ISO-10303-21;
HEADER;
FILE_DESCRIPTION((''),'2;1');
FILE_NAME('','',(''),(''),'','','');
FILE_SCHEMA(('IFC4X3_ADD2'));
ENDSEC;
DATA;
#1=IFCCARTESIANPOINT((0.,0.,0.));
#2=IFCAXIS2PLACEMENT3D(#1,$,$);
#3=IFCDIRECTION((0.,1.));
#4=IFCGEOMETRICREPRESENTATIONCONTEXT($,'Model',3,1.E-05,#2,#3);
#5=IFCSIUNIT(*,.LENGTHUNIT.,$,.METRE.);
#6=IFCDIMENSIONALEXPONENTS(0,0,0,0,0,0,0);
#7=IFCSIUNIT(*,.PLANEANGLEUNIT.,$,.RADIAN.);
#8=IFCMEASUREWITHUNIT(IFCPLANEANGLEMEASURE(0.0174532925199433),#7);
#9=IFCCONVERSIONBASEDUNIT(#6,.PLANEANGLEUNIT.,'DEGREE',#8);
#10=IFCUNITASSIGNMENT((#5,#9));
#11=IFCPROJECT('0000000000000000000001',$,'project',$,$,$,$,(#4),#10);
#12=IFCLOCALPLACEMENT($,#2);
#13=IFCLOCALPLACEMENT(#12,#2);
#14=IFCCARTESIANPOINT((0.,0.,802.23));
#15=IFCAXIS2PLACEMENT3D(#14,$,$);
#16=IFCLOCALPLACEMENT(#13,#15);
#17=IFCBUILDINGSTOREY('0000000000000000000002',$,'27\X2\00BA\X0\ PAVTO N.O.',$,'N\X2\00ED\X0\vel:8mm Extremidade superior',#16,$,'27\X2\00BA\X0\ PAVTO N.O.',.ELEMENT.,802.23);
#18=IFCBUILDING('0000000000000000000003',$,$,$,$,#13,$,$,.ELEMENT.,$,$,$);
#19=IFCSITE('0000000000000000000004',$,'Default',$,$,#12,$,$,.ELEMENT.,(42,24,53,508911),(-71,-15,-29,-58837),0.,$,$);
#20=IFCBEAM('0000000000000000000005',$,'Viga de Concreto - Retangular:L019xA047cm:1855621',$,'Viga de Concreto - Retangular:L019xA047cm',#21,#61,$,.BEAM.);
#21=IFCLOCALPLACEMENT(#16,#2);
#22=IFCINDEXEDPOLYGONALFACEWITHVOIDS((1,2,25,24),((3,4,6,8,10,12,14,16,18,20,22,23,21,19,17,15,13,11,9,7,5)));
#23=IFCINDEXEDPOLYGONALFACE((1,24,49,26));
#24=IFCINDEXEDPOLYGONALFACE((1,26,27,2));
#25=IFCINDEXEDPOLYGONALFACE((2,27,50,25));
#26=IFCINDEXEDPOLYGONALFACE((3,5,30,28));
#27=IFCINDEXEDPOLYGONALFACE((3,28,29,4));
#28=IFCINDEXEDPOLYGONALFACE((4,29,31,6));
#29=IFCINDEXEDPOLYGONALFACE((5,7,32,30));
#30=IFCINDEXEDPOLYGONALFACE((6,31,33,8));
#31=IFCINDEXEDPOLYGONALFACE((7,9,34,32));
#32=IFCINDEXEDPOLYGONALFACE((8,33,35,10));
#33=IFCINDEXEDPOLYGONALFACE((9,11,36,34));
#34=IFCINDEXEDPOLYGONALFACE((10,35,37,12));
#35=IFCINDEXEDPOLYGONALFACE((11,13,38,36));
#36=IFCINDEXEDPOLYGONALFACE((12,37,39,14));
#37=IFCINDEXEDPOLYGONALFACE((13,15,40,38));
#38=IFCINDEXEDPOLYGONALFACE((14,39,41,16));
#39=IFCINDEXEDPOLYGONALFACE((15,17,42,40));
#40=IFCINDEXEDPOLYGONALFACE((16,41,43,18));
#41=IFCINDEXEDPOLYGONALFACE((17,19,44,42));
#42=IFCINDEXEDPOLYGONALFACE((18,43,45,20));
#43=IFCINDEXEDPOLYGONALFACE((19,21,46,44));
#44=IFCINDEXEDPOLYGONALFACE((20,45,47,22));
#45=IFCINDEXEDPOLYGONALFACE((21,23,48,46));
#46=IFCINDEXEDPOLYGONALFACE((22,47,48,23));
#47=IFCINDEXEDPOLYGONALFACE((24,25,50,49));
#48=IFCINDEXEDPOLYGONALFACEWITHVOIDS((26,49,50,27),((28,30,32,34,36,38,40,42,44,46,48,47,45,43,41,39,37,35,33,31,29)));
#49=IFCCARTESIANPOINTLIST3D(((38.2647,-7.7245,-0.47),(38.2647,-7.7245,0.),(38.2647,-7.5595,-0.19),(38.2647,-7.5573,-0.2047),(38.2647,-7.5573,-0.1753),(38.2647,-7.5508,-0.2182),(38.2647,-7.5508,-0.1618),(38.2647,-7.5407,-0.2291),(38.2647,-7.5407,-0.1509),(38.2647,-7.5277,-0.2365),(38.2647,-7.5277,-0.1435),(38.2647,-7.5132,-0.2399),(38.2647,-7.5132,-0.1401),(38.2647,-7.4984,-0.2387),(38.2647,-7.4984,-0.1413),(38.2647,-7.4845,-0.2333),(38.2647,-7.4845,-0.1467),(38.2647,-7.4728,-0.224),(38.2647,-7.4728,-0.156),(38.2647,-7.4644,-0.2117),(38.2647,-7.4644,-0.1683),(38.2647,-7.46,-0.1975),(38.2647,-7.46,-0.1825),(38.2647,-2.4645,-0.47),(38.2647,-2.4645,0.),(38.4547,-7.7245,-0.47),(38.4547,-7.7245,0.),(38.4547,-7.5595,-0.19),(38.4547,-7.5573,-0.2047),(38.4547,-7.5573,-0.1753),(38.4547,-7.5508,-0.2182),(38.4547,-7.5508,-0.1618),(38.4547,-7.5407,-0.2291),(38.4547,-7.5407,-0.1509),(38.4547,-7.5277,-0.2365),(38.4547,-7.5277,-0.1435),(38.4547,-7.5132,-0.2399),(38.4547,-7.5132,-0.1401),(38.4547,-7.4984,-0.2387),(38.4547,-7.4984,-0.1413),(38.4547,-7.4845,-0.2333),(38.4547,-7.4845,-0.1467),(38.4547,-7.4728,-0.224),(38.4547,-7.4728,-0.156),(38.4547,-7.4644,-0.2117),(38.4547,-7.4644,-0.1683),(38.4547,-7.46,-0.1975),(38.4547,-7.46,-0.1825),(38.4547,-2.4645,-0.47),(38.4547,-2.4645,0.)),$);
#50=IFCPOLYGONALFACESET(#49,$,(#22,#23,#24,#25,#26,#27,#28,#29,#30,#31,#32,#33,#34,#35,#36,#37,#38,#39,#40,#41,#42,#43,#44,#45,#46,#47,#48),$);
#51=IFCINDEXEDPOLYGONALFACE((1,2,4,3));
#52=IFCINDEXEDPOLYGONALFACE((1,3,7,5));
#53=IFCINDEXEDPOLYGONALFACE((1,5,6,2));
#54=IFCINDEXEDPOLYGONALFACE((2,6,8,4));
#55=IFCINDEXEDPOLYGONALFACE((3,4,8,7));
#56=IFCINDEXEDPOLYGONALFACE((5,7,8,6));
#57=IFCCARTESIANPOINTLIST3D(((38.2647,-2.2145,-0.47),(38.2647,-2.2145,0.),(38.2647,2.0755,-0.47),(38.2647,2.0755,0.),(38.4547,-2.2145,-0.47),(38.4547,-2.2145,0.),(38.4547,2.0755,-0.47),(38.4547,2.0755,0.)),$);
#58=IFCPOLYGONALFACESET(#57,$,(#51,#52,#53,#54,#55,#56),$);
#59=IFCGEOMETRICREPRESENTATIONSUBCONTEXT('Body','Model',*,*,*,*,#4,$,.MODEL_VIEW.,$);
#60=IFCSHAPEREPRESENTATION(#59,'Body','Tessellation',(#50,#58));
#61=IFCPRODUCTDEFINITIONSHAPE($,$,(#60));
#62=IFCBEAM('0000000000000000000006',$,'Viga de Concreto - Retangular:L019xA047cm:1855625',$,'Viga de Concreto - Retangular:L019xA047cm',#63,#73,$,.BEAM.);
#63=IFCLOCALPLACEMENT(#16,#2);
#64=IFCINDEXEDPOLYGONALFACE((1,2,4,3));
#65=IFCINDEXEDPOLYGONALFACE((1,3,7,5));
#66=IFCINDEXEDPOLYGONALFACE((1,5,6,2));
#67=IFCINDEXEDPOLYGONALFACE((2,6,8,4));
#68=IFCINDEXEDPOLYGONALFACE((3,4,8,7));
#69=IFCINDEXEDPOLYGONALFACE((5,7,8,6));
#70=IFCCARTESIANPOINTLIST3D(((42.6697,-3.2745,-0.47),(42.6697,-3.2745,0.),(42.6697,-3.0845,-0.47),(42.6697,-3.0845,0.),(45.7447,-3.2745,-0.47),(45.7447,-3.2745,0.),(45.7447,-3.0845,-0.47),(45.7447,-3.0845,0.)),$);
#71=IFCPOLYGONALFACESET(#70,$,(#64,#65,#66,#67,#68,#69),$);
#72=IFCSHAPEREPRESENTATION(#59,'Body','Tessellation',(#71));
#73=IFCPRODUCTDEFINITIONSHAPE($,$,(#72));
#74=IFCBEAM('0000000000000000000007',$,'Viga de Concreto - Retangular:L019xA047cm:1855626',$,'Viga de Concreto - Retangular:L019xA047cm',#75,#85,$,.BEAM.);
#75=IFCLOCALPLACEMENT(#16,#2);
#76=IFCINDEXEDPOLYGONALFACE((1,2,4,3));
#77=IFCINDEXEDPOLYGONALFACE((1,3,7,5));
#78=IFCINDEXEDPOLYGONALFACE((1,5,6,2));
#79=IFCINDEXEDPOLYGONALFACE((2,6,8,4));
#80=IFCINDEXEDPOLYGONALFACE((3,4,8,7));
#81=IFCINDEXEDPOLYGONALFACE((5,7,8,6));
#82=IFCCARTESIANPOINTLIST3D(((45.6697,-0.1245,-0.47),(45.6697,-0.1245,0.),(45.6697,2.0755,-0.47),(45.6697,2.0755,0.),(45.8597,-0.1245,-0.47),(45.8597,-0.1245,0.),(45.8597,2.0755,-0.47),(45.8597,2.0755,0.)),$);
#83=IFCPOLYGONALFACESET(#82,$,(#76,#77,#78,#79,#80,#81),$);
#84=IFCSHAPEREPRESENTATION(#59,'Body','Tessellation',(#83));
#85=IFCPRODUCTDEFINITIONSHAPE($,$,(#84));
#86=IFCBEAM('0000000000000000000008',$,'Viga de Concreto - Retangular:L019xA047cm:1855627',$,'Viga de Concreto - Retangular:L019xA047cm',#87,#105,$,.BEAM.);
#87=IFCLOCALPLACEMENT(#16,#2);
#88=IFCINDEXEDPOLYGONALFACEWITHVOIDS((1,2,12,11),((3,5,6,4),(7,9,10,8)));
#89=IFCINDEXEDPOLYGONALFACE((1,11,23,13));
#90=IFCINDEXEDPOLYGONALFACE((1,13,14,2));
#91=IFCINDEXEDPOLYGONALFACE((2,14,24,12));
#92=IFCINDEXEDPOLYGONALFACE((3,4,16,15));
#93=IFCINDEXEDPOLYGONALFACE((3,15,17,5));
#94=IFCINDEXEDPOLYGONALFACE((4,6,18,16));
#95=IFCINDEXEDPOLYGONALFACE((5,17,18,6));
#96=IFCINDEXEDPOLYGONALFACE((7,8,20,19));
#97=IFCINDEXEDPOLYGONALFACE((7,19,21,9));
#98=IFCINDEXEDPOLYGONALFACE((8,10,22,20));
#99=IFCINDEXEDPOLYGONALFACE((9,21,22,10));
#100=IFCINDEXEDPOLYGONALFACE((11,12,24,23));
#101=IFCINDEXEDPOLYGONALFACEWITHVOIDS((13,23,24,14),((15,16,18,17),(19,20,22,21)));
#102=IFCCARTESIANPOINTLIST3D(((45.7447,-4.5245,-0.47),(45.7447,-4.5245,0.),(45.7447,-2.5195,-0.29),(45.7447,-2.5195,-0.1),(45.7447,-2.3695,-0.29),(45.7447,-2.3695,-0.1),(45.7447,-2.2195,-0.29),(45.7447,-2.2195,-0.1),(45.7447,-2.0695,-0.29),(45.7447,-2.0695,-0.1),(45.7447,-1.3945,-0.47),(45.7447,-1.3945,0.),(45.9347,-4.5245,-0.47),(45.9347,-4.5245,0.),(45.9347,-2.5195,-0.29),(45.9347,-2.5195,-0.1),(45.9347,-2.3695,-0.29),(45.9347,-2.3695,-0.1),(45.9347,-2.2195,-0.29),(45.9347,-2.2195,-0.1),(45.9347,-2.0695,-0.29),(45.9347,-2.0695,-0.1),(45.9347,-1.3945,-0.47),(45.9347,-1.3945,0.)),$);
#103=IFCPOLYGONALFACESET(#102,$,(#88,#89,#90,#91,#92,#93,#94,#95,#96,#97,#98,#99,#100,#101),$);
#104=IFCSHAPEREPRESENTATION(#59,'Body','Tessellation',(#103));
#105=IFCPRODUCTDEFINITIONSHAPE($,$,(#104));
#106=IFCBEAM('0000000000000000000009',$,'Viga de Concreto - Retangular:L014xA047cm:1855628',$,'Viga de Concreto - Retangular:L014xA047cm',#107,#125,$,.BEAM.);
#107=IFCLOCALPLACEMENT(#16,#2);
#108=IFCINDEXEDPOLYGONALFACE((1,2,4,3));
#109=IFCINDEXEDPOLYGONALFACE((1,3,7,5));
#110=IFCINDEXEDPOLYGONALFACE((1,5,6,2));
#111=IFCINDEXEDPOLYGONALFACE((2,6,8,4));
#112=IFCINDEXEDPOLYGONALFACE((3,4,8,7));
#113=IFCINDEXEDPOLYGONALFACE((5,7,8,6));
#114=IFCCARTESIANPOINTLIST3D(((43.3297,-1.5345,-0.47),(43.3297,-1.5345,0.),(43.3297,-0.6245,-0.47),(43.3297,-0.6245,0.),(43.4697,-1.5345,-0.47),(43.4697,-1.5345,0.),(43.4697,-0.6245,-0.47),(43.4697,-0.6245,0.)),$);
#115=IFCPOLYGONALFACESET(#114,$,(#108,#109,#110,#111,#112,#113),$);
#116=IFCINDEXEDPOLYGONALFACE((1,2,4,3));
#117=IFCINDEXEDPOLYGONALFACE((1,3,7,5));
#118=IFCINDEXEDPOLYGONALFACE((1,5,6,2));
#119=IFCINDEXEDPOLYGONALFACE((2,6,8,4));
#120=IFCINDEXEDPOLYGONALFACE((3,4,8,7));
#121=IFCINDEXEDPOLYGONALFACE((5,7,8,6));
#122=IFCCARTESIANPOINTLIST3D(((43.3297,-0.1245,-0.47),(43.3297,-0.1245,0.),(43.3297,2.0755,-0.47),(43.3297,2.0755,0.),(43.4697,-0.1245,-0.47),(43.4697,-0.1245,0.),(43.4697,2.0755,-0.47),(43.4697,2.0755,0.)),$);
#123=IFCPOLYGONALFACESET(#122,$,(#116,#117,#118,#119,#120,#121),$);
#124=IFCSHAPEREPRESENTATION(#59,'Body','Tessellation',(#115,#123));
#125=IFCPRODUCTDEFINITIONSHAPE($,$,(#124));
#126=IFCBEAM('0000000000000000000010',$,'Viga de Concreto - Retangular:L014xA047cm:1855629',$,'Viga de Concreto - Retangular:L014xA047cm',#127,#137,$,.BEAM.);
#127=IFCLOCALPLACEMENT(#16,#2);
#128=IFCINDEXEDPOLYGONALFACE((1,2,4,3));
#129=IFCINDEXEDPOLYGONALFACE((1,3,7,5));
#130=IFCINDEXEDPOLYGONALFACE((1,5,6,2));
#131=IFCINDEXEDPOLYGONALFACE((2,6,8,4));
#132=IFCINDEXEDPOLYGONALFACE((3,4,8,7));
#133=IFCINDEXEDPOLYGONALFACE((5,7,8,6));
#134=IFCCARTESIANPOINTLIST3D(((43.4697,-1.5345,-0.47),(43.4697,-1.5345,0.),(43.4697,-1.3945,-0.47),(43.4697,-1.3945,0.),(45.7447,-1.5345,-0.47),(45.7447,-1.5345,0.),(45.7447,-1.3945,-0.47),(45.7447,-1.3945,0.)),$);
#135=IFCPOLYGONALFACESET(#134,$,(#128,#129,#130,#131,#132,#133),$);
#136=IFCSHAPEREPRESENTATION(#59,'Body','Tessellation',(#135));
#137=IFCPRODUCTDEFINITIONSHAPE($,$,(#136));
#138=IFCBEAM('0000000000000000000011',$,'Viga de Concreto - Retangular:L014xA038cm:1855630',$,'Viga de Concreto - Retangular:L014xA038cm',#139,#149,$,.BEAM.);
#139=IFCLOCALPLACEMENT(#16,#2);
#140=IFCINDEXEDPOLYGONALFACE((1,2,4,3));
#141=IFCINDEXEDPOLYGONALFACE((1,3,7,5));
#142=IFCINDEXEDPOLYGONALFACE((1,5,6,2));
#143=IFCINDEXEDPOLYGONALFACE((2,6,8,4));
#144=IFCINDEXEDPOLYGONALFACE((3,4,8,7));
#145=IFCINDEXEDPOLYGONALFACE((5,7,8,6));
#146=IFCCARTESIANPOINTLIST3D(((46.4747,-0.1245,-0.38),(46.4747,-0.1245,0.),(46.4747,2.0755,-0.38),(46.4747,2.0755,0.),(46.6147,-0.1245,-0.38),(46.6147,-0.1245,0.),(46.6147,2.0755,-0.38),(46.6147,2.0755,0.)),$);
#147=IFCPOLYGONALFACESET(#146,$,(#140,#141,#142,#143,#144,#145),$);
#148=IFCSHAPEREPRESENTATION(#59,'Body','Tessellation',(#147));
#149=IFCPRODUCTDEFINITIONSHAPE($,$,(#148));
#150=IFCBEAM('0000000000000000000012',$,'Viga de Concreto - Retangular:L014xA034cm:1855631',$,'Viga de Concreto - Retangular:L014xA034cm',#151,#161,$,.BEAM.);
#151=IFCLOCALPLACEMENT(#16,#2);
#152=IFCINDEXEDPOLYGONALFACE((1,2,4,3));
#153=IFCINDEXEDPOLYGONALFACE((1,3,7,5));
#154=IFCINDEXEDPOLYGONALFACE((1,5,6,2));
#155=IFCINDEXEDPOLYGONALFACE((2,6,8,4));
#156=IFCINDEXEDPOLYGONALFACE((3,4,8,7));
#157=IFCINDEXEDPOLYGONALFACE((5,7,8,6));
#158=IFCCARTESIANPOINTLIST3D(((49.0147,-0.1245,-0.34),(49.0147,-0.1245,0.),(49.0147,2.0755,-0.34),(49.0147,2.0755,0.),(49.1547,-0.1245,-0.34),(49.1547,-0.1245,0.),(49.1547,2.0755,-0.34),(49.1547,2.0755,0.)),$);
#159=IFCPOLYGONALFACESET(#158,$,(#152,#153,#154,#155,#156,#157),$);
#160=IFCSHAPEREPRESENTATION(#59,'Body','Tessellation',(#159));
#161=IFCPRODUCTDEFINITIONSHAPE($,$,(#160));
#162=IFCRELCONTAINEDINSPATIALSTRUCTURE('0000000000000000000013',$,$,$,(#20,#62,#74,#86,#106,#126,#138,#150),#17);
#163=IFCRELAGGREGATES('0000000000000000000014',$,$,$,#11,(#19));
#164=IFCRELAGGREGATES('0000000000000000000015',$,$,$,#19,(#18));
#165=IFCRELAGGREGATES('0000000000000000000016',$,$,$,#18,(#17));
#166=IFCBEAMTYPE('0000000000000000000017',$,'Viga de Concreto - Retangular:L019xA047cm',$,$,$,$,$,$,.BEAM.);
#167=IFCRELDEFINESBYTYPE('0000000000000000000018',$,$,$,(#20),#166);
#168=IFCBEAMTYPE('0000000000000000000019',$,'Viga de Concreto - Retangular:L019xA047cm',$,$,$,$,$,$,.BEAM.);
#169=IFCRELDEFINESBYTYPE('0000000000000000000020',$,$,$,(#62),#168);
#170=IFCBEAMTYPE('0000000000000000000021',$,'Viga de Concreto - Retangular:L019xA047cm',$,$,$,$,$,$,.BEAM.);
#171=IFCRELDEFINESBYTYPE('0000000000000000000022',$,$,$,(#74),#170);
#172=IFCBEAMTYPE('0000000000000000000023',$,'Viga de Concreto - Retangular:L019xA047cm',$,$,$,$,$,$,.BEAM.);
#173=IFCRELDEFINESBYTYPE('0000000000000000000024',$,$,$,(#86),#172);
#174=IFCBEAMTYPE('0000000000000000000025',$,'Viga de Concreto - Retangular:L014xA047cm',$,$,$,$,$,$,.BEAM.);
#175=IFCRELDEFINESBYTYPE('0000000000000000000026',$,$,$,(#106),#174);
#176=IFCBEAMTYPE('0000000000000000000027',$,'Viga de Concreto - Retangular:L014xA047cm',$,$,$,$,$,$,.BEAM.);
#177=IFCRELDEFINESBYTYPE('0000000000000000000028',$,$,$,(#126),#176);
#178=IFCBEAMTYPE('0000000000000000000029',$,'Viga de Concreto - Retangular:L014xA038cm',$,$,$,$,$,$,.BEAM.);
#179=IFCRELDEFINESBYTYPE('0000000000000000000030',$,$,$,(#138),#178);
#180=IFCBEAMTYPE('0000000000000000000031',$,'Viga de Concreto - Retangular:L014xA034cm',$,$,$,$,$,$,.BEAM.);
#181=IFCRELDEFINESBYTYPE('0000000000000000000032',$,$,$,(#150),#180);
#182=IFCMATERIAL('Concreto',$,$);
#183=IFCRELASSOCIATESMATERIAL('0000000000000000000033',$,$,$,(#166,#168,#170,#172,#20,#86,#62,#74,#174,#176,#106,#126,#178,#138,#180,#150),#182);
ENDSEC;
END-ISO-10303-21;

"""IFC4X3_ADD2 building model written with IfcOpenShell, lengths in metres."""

from ifc_helpers import new_model, entity, si_unit, converted_unit, direction, frame, frame_2d, origin, origin_2d_with_axis, place, context, subcontext, project, spatial, rectangle, circle, extrude, boolean, source, transform, mapped, material, material_profile, profile_set, profile_usage, type_object, type_shapes, element, save


model = new_model("IFC4X3_ADD2")

# Units and contexts
model_context = context("Model", 3, precision=1e-05, world=origin(), true_north=direction((0.0, 1.0)))
body_context = subcontext(model_context, "Body", "Model", "MODEL_VIEW")
ifc_project = project(units=[si_unit("LENGTHUNIT", "METRE"), converted_unit("PLANEANGLEUNIT", "DEGREE", entity("IfcPlaneAngleMeasure", 0.0174532925199433), si_unit("PLANEANGLEUNIT", "RADIAN"), dimensions=[0, 0, 0, 0, 0, 0, 0])], contexts=[model_context])

# Site, building, storey
site_placement = place(None, origin())
site = spatial("IfcSite", under=ifc_project, at=site_placement, Name="Default", CompositionType="ELEMENT", RefLatitude=(42, 24, 53, 508911), RefLongitude=(-71, -15, -29, -58837), RefElevation=0.0)
building_placement = place(site_placement, origin())
building = spatial("IfcBuilding", under=site, at=building_placement, CompositionType="ELEMENT")
storey_placement = place(building_placement, frame((0.0, 0.0, 802.23)))
storey = spatial("IfcBuildingStorey", under=building, at=storey_placement, Name="27º PAVTO N.O.", ObjectType="Nível:8mm Extremidade superior", LongName="27º PAVTO N.O.", CompositionType="ELEMENT", Elevation=802.23)

# Beams
ifc_material = material(Name="Concreto")
ifc_material_profile_1 = material_profile(ifc_material, rectangle(XDim=0.47, YDim=0.19, at=frame_2d((0.0, 0.0), x_axis=(0.0, 1.0))), Name="L019xA047cm")
ifc_profile_set_1 = profile_set([ifc_material_profile_1], Name="L019xA047cm")
ifc_profile_usage_1 = profile_usage(ifc_profile_set_1, cardinal=8)
ifc_material_profile_2 = material_profile(ifc_material, rectangle(XDim=0.47, YDim=0.14, at=frame_2d((0.0, 0.0), x_axis=(0.0, 1.0))), Name="L014xA047cm")
ifc_profile_set_2 = profile_set([ifc_material_profile_2], Name="L014xA047cm")
ifc_material_profile_3 = material_profile(ifc_material, rectangle(XDim=0.34, YDim=0.14, at=frame_2d((0.0, 0.0), x_axis=(0.0, 1.0))), Name="L014xA034cm")
ifc_profile_set_3 = profile_set([ifc_material_profile_3], Name="L014xA034cm")
ifc_profile_usage_2 = profile_usage(ifc_profile_set_3, cardinal=8)
ifc_profile_usage_3 = profile_usage(ifc_profile_set_2, cardinal=8)
ifc_material_profile_4 = material_profile(ifc_material, rectangle(XDim=0.38, YDim=0.14, at=frame_2d((0.0, 0.0), x_axis=(1.0, 0.0))), Name="L014xA038cm")
ifc_profile_set_4 = profile_set([ifc_material_profile_4], Name="L014xA038cm")
ifc_profile_usage_4 = profile_usage(ifc_profile_set_4, cardinal=8)
beam_type_1 = type_object("IfcBeamType", Name="Viga de Concreto - Retangular:L019xA047cm", PredefinedType="BEAM", material=ifc_profile_set_1)
shared_shape_1 = source(origin(), body_context, "Body", "SweptSolid", [
    boolean("DIFFERENCE", extrude(rectangle(XDim=0.47, YDim=0.19, at=frame_2d((0.0, 0.0), x_axis=(0.0, 1.0))), frame((38.3597, -2.4645, 801.995), z_axis=(0.0, -1.0, 0.0), x_axis=(-1.0, 0.0, 0.0)), (0.0, 0.0, 1.0), 5.26), extrude(circle(Radius=0.05, at=frame_2d((0.0, 0.0), x_axis=(1.0, 0.0))), frame((38.4547, -7.5095, 802.04), z_axis=(-1.0, 0.0, 0.0), x_axis=(0.0, -1.0, 0.0)), (0.0, 0.0, 1.0), 0.19)),
    extrude(rectangle(XDim=0.47, YDim=0.19, at=frame_2d((0.0, 0.0), x_axis=(0.0, 1.0))), frame((38.3597, 2.0755, 801.995), z_axis=(0.0, -1.0, 0.0), x_axis=(-1.0, 0.0, 0.0)), (0.0, 0.0, 1.0), 4.29),
])
type_shapes(beam_type_1, [shared_shape_1])
beam_1_placement = place(storey_placement, frame((0.0, 0.0, -802.23)))
element("IfcBeam", 1, at=beam_1_placement, inside=storey, type_object=beam_type_1, material=ifc_material, Name="Viga de Concreto - Retangular:L019xA047cm:1855621", ObjectType="Viga de Concreto - Retangular:L019xA047cm", PredefinedType="BEAM", context=body_context, shape_type="MappedRepresentation", body=[
    mapped(shared_shape_1, transform((0.0, 0.0, 0.0), scale=1.0)),
])
beam_type_2 = type_object("IfcBeamType", Name="Viga de Concreto - Retangular:L019xA047cm", PredefinedType="BEAM", material=ifc_profile_set_1)
shared_shape_2 = source(origin(), body_context, "Body", "SweptSolid", [
    extrude(rectangle(XDim=0.47, YDim=0.19, at=origin_2d_with_axis()), frame((42.6697, -3.1795, 801.995), z_axis=(1.0, 0.0, 0.0), x_axis=(0.0, 0.0, -1.0)), (0.0, 0.0, 1.0), 3.075),
])
type_shapes(beam_type_2, [shared_shape_2])
beam_2_placement = place(storey_placement, frame((0.0, 0.0, -802.23)))
element("IfcBeam", 2, at=beam_2_placement, inside=storey, type_object=beam_type_2, material=ifc_profile_usage_1, Name="Viga de Concreto - Retangular:L019xA047cm:1855625", ObjectType="Viga de Concreto - Retangular:L019xA047cm", PredefinedType="BEAM", context=body_context, shape_type="MappedRepresentation", body=[
    mapped(shared_shape_2, transform((0.0, 0.0, 0.0), scale=1.0)),
])
beam_type_3 = type_object("IfcBeamType", Name="Viga de Concreto - Retangular:L019xA047cm", PredefinedType="BEAM", material=ifc_profile_set_1)
shared_shape_3 = source(origin(), body_context, "Body", "SweptSolid", [
    extrude(rectangle(XDim=0.47, YDim=0.19, at=frame_2d((0.0, 0.0), x_axis=(0.0, 1.0))), frame((45.7647, 2.0755, 801.995), z_axis=(0.0, -1.0, 0.0), x_axis=(-1.0, 0.0, 0.0)), (0.0, 0.0, 1.0), 2.2),
])
type_shapes(beam_type_3, [shared_shape_3])
beam_3_placement = place(storey_placement, frame((0.0, 0.0, -802.23)))
element("IfcBeam", 3, at=beam_3_placement, inside=storey, type_object=beam_type_3, material=ifc_profile_usage_1, Name="Viga de Concreto - Retangular:L019xA047cm:1855626", ObjectType="Viga de Concreto - Retangular:L019xA047cm", PredefinedType="BEAM", context=body_context, shape_type="MappedRepresentation", body=[
    mapped(shared_shape_3, transform((0.0, 0.0, 0.0), scale=1.0)),
])
beam_type_4 = type_object("IfcBeamType", Name="Viga de Concreto - Retangular:L019xA047cm", PredefinedType="BEAM", material=ifc_profile_set_1)
shared_shape_4 = source(origin(), body_context, "Body", "CSG", [
    boolean("DIFFERENCE", boolean("DIFFERENCE", extrude(rectangle(XDim=0.47, YDim=0.19, at=frame_2d((0.0, 0.0), x_axis=(0.0, 1.0))), frame((45.8397, -1.3945, 801.995), z_axis=(0.0, -1.0, 0.0), x_axis=(-1.0, 0.0, 0.0)), (0.0, 0.0, 1.0), 3.13), extrude(rectangle(XDim=0.19, YDim=0.15, at=frame_2d((0.0, 0.0), x_axis=(0.0, 1.0))), frame((45.9347, -2.4445, 802.035), z_axis=(-1.0, 0.0, 0.0), x_axis=(0.0, 1.0, 0.0)), (0.0, 0.0, 1.0), 0.19)), extrude(rectangle(XDim=0.19, YDim=0.15, at=frame_2d((0.0, 0.0), x_axis=(0.0, 1.0))), frame((45.9347, -2.1445, 802.035), z_axis=(-1.0, 0.0, 0.0), x_axis=(0.0, 1.0, 0.0)), (0.0, 0.0, 1.0), 0.19)),
])
type_shapes(beam_type_4, [shared_shape_4])
beam_4_placement = place(storey_placement, frame((0.0, 0.0, -802.23)))
element("IfcBeam", 4, at=beam_4_placement, inside=storey, type_object=beam_type_4, material=ifc_material, Name="Viga de Concreto - Retangular:L019xA047cm:1855627", ObjectType="Viga de Concreto - Retangular:L019xA047cm", PredefinedType="BEAM", context=body_context, shape_type="MappedRepresentation", body=[
    mapped(shared_shape_4, transform((0.0, 0.0, 0.0), scale=1.0)),
])
beam_type_5 = type_object("IfcBeamType", Name="Viga de Concreto - Retangular:L014xA047cm", PredefinedType="BEAM", material=ifc_profile_set_2)
shared_shape_5 = source(origin(), body_context, "Body", "SweptSolid", [
    extrude(rectangle(XDim=0.47, YDim=0.14, at=frame_2d((0.0, 0.0), x_axis=(0.0, 1.0))), frame((43.3997, -0.6245, 801.995), z_axis=(0.0, -1.0, 0.0), x_axis=(-1.0, 0.0, 0.0)), (0.0, 0.0, 1.0), 0.91),
    extrude(rectangle(XDim=0.47, YDim=0.14, at=frame_2d((0.0, 0.0), x_axis=(0.0, 1.0))), frame((43.3997, 2.0755, 801.995), z_axis=(0.0, -1.0, 0.0), x_axis=(-1.0, 0.0, 0.0)), (0.0, 0.0, 1.0), 2.2),
])
type_shapes(beam_type_5, [shared_shape_5])
beam_5_placement = place(storey_placement, frame((0.0, 0.0, -802.23)))
element("IfcBeam", 5, at=beam_5_placement, inside=storey, type_object=beam_type_5, material=ifc_profile_usage_3, Name="Viga de Concreto - Retangular:L014xA047cm:1855628", ObjectType="Viga de Concreto - Retangular:L014xA047cm", PredefinedType="BEAM", context=body_context, shape_type="MappedRepresentation", body=[
    mapped(shared_shape_5, transform((0.0, 0.0, 0.0), scale=1.0)),
])
beam_type_6 = type_object("IfcBeamType", Name="Viga de Concreto - Retangular:L014xA047cm", PredefinedType="BEAM", material=ifc_profile_set_2)
shared_shape_6 = source(origin(), body_context, "Body", "SweptSolid", [
    extrude(rectangle(XDim=0.47, YDim=0.14, at=frame_2d((0.0, 0.0), x_axis=(1.0, 0.0))), frame((43.4697, -1.4645, 801.995), z_axis=(1.0, 0.0, 0.0), x_axis=(0.0, 0.0, -1.0)), (0.0, 0.0, 1.0), 2.275),
])
type_shapes(beam_type_6, [shared_shape_6])
beam_6_placement = place(storey_placement, frame((0.0, 0.0, -802.23)))
element("IfcBeam", 6, at=beam_6_placement, inside=storey, type_object=beam_type_6, material=ifc_profile_usage_3, Name="Viga de Concreto - Retangular:L014xA047cm:1855629", ObjectType="Viga de Concreto - Retangular:L014xA047cm", PredefinedType="BEAM", context=body_context, shape_type="MappedRepresentation", body=[
    mapped(shared_shape_6, transform((0.0, 0.0, 0.0), scale=1.0)),
])
beam_type_7 = type_object("IfcBeamType", Name="Viga de Concreto - Retangular:L014xA038cm", PredefinedType="BEAM", material=ifc_profile_set_4)
shared_shape_7 = source(origin(), body_context, "Body", "SweptSolid", [
    extrude(rectangle(XDim=0.38, YDim=0.14, at=frame_2d((0.0, 0.0), x_axis=(0.0, 1.0))), frame((46.5447, 2.0755, 802.04), z_axis=(0.0, -1.0, 0.0), x_axis=(-1.0, 0.0, 0.0)), (0.0, 0.0, 1.0), 2.2),
])
type_shapes(beam_type_7, [shared_shape_7])
beam_7_placement = place(storey_placement, frame((0.0, 0.0, -802.23)))
element("IfcBeam", 7, at=beam_7_placement, inside=storey, type_object=beam_type_7, material=ifc_profile_usage_4, Name="Viga de Concreto - Retangular:L014xA038cm:1855630", ObjectType="Viga de Concreto - Retangular:L014xA038cm", PredefinedType="BEAM", context=body_context, shape_type="MappedRepresentation", body=[
    mapped(shared_shape_7, transform((0.0, 0.0, 0.0), scale=1.0)),
])
beam_type_8 = type_object("IfcBeamType", Name="Viga de Concreto - Retangular:L014xA034cm", PredefinedType="BEAM", material=ifc_profile_set_3)
shared_shape_8 = source(origin(), body_context, "Body", "SweptSolid", [
    extrude(rectangle(XDim=0.34, YDim=0.14, at=frame_2d((0.0, 0.0), x_axis=(0.0, 1.0))), frame((49.0847, 2.0755, 802.06), z_axis=(0.0, -1.0, 0.0), x_axis=(-1.0, 0.0, 0.0)), (0.0, 0.0, 1.0), 2.2),
])
type_shapes(beam_type_8, [shared_shape_8])
beam_8_placement = place(storey_placement, frame((0.0, 0.0, -802.23)))
element("IfcBeam", 8, at=beam_8_placement, inside=storey, type_object=beam_type_8, material=ifc_profile_usage_2, Name="Viga de Concreto - Retangular:L014xA034cm:1855631", ObjectType="Viga de Concreto - Retangular:L014xA034cm", PredefinedType="BEAM", context=body_context, shape_type="MappedRepresentation", body=[
    mapped(shared_shape_8, transform((0.0, 0.0, 0.0), scale=1.0)),
])

save(model, "model.ifc")
